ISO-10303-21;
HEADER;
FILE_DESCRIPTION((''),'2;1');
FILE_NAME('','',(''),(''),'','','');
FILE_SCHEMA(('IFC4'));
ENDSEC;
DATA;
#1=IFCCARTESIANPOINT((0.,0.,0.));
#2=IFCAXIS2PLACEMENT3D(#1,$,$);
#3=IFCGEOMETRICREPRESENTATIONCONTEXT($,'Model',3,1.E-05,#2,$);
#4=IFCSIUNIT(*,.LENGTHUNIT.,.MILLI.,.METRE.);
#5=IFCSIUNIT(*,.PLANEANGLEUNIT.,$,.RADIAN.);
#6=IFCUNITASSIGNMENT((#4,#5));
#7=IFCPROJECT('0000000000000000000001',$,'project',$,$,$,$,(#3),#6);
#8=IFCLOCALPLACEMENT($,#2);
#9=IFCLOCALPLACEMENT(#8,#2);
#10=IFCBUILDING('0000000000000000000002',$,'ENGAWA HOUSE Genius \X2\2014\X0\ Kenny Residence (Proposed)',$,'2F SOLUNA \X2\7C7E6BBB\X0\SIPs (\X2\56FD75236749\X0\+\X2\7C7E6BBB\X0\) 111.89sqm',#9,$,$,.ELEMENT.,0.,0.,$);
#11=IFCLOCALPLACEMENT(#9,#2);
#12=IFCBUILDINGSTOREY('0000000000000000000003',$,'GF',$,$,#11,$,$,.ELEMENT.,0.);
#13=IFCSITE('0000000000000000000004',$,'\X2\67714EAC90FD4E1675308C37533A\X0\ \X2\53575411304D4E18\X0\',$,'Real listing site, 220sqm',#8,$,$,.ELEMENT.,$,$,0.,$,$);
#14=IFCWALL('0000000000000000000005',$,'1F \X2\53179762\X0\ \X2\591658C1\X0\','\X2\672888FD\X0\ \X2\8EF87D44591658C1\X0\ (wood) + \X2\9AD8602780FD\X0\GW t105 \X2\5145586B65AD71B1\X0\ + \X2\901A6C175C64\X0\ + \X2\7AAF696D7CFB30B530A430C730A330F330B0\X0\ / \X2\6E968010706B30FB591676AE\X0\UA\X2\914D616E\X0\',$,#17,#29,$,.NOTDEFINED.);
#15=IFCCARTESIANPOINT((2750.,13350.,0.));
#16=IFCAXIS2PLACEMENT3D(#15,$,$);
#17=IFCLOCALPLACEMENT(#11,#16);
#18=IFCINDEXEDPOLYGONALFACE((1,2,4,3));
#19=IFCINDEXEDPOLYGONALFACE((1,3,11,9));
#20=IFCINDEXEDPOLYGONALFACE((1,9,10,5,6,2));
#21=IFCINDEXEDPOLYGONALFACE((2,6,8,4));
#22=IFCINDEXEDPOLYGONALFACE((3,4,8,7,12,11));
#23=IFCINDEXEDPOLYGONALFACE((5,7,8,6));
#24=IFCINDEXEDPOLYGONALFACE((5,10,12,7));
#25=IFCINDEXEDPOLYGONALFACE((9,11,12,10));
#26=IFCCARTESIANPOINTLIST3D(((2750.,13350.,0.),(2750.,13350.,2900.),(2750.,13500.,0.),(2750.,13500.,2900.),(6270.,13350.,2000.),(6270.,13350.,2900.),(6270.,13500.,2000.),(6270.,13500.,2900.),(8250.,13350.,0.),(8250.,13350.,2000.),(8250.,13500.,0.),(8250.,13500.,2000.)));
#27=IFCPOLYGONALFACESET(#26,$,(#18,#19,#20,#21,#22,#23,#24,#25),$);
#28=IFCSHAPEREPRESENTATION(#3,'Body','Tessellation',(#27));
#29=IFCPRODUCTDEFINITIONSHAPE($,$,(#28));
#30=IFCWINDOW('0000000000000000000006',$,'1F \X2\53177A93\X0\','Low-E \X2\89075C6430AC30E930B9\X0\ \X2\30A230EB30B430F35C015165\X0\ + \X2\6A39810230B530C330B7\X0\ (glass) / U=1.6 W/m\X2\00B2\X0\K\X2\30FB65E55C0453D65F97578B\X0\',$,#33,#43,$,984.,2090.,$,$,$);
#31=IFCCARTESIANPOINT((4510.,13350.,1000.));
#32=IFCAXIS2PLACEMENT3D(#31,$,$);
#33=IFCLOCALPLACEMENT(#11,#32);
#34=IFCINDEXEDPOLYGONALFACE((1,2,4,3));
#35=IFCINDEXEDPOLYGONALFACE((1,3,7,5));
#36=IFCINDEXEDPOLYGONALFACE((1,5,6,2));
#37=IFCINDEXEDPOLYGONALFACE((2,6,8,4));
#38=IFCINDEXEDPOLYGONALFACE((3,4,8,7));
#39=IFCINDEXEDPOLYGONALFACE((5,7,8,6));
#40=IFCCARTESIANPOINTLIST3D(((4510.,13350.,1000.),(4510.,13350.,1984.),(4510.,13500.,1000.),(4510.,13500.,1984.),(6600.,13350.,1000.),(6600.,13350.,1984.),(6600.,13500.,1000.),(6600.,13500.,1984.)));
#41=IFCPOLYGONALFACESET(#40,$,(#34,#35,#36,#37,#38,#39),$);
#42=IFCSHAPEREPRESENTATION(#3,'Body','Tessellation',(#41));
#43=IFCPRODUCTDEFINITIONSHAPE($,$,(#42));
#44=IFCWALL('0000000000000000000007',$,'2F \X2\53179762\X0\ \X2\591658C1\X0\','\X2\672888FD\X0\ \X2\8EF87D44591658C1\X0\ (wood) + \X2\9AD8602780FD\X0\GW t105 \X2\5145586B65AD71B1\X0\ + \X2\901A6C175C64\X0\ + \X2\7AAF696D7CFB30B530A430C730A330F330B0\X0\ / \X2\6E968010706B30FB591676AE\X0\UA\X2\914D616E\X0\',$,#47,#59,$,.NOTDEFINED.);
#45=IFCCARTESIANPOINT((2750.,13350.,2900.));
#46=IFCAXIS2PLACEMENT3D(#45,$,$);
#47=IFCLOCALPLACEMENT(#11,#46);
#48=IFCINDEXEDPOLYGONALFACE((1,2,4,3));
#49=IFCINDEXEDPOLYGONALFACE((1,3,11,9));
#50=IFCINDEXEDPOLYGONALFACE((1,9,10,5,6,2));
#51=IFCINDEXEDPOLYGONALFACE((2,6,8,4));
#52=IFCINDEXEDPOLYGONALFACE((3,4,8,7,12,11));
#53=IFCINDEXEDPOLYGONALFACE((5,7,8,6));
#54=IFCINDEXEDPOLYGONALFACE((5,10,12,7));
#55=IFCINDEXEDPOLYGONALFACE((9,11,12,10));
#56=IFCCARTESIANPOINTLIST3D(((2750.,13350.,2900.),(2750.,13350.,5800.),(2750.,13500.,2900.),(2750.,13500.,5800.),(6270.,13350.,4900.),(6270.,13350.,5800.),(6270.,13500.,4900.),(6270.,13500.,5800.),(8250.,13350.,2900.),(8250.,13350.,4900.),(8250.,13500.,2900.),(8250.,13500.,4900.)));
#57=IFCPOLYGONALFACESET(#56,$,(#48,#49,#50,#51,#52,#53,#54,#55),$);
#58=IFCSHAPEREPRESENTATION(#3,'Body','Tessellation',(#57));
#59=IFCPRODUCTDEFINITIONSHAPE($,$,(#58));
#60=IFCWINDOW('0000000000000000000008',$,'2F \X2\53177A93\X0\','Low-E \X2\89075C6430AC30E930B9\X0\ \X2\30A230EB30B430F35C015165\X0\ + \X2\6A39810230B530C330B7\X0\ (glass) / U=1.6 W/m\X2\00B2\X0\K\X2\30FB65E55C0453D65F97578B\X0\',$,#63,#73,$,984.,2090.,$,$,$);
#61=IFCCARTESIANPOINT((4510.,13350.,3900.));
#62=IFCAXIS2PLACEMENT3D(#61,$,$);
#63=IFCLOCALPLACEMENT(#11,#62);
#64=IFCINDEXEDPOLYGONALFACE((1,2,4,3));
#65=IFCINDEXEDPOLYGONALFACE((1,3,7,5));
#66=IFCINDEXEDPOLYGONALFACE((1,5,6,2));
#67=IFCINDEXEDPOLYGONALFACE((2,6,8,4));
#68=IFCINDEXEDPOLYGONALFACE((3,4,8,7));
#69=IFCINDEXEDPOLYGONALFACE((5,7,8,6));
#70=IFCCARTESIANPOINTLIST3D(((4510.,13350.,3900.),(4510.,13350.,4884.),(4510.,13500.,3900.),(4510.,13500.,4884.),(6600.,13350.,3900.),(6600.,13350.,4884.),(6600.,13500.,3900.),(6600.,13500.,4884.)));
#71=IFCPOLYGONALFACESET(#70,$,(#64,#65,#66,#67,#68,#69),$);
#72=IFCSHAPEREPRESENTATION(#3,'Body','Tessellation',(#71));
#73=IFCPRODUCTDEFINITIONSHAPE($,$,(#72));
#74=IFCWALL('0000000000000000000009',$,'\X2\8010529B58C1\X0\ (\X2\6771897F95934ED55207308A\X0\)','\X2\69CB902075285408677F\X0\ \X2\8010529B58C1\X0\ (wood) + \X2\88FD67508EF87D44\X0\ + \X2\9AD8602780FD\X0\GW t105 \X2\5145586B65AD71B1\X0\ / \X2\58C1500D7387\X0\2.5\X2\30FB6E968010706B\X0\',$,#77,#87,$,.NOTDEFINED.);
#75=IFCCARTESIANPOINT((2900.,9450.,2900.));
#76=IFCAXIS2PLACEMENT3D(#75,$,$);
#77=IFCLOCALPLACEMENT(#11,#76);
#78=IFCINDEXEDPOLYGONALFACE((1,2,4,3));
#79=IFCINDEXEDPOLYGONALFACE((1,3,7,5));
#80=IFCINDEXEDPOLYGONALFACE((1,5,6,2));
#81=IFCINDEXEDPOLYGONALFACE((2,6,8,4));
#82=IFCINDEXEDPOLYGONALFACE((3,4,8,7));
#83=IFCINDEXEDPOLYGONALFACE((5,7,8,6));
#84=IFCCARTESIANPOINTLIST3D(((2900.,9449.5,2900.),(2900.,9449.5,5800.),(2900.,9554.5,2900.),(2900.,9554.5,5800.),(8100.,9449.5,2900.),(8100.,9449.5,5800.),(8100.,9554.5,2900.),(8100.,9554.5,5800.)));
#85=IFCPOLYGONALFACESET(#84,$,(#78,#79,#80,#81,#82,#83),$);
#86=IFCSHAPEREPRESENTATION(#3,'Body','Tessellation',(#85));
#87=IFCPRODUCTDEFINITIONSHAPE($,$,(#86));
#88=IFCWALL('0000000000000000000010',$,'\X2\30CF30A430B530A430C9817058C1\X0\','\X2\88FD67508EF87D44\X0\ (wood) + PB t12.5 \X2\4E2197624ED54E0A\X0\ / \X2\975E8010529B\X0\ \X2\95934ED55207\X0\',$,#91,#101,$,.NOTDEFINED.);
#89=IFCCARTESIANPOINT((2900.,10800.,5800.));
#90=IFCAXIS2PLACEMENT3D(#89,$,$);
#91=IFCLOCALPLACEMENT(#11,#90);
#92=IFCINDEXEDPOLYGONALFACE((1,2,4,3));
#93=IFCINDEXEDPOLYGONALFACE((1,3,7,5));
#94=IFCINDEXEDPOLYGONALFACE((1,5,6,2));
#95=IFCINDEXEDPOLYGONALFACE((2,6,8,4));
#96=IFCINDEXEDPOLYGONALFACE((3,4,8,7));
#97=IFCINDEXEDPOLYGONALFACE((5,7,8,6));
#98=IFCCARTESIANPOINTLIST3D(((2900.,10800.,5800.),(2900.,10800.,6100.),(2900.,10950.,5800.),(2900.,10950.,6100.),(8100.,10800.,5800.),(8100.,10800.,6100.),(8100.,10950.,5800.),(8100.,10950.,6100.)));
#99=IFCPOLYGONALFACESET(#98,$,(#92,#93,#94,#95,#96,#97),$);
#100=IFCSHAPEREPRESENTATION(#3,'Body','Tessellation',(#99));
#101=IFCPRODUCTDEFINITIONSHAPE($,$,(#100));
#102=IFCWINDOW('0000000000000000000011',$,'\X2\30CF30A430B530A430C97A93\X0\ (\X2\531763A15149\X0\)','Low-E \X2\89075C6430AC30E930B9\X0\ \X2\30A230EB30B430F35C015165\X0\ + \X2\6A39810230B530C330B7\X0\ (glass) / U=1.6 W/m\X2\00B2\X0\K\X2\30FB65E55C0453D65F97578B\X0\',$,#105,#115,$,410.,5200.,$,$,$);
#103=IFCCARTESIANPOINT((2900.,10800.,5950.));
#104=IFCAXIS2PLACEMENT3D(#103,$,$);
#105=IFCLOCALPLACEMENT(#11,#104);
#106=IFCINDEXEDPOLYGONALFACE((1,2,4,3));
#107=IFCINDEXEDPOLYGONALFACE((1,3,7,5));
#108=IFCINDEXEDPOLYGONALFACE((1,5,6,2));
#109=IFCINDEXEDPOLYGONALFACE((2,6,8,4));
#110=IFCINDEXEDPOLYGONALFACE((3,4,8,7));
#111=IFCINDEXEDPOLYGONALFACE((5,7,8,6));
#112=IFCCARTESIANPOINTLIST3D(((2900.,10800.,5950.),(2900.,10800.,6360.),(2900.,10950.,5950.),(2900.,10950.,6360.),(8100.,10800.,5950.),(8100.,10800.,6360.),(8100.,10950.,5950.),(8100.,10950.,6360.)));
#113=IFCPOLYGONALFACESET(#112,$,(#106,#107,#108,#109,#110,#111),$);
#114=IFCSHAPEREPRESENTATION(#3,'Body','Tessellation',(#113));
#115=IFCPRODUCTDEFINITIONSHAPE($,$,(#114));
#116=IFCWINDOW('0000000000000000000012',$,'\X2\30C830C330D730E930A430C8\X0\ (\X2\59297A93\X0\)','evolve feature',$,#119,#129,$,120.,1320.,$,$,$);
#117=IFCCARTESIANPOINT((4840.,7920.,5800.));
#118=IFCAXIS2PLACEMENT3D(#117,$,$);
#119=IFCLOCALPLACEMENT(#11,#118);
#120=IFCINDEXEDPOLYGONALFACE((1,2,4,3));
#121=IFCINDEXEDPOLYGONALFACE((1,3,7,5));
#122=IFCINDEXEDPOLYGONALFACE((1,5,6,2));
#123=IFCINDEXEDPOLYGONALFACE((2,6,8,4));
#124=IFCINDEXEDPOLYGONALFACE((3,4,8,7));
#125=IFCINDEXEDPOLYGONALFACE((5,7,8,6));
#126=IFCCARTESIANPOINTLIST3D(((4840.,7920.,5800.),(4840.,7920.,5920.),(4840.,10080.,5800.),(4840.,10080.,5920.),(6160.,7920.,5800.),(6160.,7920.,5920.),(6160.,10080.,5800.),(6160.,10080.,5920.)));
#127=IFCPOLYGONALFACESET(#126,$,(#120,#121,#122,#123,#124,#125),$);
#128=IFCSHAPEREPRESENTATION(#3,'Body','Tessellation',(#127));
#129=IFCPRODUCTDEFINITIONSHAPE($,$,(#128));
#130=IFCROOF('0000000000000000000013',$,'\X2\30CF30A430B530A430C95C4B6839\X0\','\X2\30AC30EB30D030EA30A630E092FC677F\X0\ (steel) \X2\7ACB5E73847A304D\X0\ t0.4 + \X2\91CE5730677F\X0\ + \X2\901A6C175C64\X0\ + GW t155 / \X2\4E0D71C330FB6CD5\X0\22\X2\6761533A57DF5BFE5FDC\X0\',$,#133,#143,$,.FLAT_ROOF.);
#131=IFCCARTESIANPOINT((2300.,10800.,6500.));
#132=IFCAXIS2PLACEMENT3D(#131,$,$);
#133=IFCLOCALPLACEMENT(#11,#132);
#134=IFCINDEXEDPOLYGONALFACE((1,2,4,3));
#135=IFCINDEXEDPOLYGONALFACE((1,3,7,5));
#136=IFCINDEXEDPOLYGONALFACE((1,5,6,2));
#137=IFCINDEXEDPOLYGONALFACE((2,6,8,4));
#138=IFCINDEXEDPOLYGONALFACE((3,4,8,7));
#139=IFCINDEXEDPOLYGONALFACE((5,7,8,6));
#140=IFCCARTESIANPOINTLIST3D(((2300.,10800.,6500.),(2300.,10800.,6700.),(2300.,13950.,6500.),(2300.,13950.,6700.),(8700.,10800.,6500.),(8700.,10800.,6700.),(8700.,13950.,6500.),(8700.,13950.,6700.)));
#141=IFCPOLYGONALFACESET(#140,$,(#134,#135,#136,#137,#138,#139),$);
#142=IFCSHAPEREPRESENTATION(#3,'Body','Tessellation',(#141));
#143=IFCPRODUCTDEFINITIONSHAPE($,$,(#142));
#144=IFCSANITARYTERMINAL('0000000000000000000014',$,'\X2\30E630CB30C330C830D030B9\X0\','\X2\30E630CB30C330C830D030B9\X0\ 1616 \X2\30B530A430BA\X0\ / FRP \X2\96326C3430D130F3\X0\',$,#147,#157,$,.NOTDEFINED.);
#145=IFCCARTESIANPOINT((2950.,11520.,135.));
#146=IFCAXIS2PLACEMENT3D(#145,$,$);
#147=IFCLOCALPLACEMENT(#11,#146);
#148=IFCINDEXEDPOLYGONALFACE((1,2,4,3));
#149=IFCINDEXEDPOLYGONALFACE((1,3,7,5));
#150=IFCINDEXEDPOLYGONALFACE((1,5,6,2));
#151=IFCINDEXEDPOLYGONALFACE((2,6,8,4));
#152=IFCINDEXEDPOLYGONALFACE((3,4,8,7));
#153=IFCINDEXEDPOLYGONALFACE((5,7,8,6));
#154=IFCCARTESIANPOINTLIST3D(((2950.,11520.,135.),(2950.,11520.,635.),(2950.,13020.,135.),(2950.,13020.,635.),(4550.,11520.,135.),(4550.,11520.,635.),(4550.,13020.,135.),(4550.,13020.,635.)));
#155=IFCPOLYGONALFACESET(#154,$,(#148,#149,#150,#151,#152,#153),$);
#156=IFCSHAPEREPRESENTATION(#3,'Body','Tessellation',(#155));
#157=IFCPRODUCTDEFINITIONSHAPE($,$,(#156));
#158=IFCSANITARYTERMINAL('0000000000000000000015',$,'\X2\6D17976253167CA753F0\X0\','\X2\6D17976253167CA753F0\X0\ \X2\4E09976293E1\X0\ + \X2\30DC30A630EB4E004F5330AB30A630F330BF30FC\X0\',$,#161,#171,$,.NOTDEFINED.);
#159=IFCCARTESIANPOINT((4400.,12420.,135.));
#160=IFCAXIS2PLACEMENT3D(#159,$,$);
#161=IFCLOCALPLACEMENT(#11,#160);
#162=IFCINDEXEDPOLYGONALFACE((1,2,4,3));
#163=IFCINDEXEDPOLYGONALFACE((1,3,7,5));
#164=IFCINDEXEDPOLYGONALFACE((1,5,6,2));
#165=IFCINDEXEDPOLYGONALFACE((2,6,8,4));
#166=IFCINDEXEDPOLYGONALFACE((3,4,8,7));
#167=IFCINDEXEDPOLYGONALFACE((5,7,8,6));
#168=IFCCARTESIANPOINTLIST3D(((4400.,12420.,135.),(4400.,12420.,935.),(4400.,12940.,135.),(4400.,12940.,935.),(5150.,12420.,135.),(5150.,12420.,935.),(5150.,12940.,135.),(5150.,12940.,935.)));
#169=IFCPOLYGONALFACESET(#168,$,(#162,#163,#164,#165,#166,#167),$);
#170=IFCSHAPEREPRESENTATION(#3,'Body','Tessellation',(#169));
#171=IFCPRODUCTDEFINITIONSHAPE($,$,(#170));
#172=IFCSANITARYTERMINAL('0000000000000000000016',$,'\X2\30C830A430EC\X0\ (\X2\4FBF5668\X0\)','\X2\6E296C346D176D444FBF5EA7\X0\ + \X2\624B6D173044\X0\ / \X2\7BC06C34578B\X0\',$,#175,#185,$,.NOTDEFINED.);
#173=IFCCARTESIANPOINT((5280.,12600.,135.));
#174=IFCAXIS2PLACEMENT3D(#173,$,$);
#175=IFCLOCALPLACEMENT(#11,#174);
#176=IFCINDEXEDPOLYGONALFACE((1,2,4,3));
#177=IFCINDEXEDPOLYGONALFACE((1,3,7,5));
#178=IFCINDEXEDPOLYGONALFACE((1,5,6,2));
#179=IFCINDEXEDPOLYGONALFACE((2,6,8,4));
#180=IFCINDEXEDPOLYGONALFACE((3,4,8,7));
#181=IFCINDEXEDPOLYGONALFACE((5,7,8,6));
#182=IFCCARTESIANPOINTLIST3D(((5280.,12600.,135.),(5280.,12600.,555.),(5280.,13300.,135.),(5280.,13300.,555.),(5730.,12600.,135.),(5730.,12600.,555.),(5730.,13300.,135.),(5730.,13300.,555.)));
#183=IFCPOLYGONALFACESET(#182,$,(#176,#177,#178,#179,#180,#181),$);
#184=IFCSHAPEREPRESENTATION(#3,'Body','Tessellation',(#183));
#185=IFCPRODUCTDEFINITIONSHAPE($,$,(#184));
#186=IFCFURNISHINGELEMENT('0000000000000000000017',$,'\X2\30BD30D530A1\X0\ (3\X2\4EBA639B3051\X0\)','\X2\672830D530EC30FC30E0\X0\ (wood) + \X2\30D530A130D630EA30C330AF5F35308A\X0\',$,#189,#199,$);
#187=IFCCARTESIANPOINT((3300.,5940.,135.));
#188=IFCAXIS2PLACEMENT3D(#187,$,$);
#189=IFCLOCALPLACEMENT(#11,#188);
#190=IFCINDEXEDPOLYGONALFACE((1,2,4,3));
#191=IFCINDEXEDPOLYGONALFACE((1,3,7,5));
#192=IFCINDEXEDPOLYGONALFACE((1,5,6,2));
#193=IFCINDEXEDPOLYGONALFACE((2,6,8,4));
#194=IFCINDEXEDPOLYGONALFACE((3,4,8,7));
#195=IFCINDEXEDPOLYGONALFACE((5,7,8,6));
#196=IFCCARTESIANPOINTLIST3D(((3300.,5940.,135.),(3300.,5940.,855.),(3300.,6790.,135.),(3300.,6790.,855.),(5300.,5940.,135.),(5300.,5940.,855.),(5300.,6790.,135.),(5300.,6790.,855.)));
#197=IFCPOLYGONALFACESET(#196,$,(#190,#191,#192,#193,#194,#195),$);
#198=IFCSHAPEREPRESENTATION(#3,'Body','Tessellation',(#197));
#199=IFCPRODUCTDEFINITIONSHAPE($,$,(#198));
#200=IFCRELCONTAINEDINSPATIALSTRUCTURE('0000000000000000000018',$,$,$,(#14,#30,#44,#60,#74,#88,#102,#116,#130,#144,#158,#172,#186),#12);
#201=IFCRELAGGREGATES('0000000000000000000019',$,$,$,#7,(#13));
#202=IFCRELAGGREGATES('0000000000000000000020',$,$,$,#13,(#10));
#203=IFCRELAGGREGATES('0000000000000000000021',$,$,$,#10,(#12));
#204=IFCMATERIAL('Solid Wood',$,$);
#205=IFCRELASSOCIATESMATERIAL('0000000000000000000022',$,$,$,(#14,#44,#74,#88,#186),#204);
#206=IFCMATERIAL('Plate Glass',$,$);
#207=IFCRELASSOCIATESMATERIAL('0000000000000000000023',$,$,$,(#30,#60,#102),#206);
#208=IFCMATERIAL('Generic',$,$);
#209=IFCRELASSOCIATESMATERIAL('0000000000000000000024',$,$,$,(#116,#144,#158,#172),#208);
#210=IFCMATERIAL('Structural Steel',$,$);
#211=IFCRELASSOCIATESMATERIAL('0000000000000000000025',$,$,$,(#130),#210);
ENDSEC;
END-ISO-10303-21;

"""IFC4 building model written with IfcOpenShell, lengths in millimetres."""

from ifc_helpers import new_model, si_unit, frame, frame_2d, origin, place, context, project, spatial, rectangle, extrude, material, element, fill, save


model = new_model("IFC4")

# Units and contexts
model_context = context("Model", 3, precision=1e-05, world=origin())
ifc_project = project(units=[si_unit("LENGTHUNIT", "METRE", prefix="MILLI"), si_unit("PLANEANGLEUNIT", "RADIAN")], contexts=[model_context])

# Site, building, storey
site_placement = place(None, origin())
site = spatial("IfcSite", under=ifc_project, at=site_placement, Name="東京都世田谷区 南向き丘", ObjectType="Real listing site, 220sqm", CompositionType="ELEMENT", RefElevation=0.0)
building_placement = place(site_placement, origin())
building = spatial("IfcBuilding", under=site, at=building_placement, Name="ENGAWA HOUSE Genius — Kenny Residence (Proposed)", ObjectType="2F SOLUNA 籾殻SIPs (国産杉+籾殻) 111.89sqm", CompositionType="ELEMENT", ElevationOfRefHeight=0.0, ElevationOfTerrain=0.0)
storey_placement = place(building_placement, origin())
storey = spatial("IfcBuildingStorey", under=building, at=storey_placement, Name="GF", CompositionType="ELEMENT", Elevation=0.0)

# Wall, opening, window
ifc_material_1 = material(Name="Solid Wood")
wall_1_placement = place(storey_placement, frame((2750.0, 13350.0, 0.0)))
wall_1 = element("IfcWall", 1, at=wall_1_placement, inside=storey, material=ifc_material_1, Name="1F 北面 外壁", Description="木製 軸組外壁 (wood) + 高性能GW t105 充填断熱 + 通気層 + 窯業系サイディング / 準耐火・外皮UA配慮", PredefinedType="NOTDEFINED", context=model_context, shape_type="SweptSolid", body=[
    extrude(rectangle(XDim=5500.0, YDim=150.0, at=frame_2d((2750.0, 75.0))), frame((2750.0, 13350.0, 0.0)), (0.0, 0.0, 1.0), 2900.0),
])
opening_1_placement = place(storey_placement, frame((4510.0, 13350.0, 1000.0)))
opening_1 = element("IfcOpeningElement", 2, at=opening_1_placement, cuts=wall_1, PredefinedType="NOTDEFINED", context=model_context, shape_type="SweptSolid", body=[
    extrude(rectangle(XDim=2090.0, YDim=150.0, at=frame_2d((1045.0, 75.0))), frame((4510.0, 13350.0, 1000.0)), (0.0, 0.0, 1.0), 984.0),
])
ifc_material_2 = material(Name="Plate Glass")
window_1_placement = place(storey_placement, frame((4510.0, 13350.0, 1000.0)))
window_1 = element("IfcWindow", 3, at=window_1_placement, inside=storey, material=ifc_material_2, Name="1F 北窓", Description="Low-E 複層ガラス アルゴン封入 + 樹脂サッシ (glass) / U=1.6 W/m²K・日射取得型", OverallHeight=984.0, OverallWidth=2090.0, context=model_context, shape_type="SweptSolid", body=[
    extrude(rectangle(XDim=2090.0, YDim=150.0, at=frame_2d((1045.0, 75.0))), frame((4510.0, 13350.0, 1000.0)), (0.0, 0.0, 1.0), 984.0),
])
fill(opening_1, window_1)

# Wall, opening, window
wall_2_placement = place(storey_placement, frame((2750.0, 13350.0, 2900.0)))
wall_2 = element("IfcWall", 4, at=wall_2_placement, inside=storey, material=ifc_material_1, Name="2F 北面 外壁", Description="木製 軸組外壁 (wood) + 高性能GW t105 充填断熱 + 通気層 + 窯業系サイディング / 準耐火・外皮UA配慮", PredefinedType="NOTDEFINED", context=model_context, shape_type="SweptSolid", body=[
    extrude(rectangle(XDim=5500.0, YDim=150.0, at=frame_2d((2750.0, 75.0))), frame((2750.0, 13350.0, 2900.0)), (0.0, 0.0, 1.0), 2900.0),
])
opening_2_placement = place(storey_placement, frame((4510.0, 13350.0, 3900.0)))
opening_2 = element("IfcOpeningElement", 5, at=opening_2_placement, cuts=wall_2, PredefinedType="NOTDEFINED", context=model_context, shape_type="SweptSolid", body=[
    extrude(rectangle(XDim=2090.0, YDim=150.0, at=frame_2d((1045.0, 75.0))), frame((4510.0, 13350.0, 3900.0)), (0.0, 0.0, 1.0), 984.0),
])
window_2_placement = place(storey_placement, frame((4510.0, 13350.0, 3900.0)))
window_2 = element("IfcWindow", 6, at=window_2_placement, inside=storey, material=ifc_material_2, Name="2F 北窓", Description="Low-E 複層ガラス アルゴン封入 + 樹脂サッシ (glass) / U=1.6 W/m²K・日射取得型", OverallHeight=984.0, OverallWidth=2090.0, context=model_context, shape_type="SweptSolid", body=[
    extrude(rectangle(XDim=2090.0, YDim=150.0, at=frame_2d((1045.0, 75.0))), frame((4510.0, 13350.0, 3900.0)), (0.0, 0.0, 1.0), 984.0),
])
fill(opening_2, window_2)

# Wall
wall_3_placement = place(storey_placement, frame((2900.0, 9450.0, 2900.0)))
element("IfcWall", 7, at=wall_3_placement, inside=storey, material=ifc_material_1, Name="耐力壁 (東西間仕切り)", Description="構造用合板 耐力壁 (wood) + 製材軸組 + 高性能GW t105 充填断熱 / 壁倍率2.5・準耐火", PredefinedType="NOTDEFINED", context=model_context, shape_type="SweptSolid", body=[
    extrude(rectangle(XDim=5200.0, YDim=105.0, at=frame_2d((2600.0, 52.0))), frame((2900.0, 9450.0, 2900.0)), (0.0, 0.0, 1.0), 2900.0),
])

# Wall, opening, window
wall_4_placement = place(storey_placement, frame((2900.0, 10800.0, 5800.0)))
wall_4 = element("IfcWall", 8, at=wall_4_placement, inside=storey, material=ifc_material_1, Name="ハイサイド腰壁", Description="製材軸組 (wood) + PB t12.5 両面仕上 / 非耐力 間仕切", PredefinedType="NOTDEFINED", context=model_context, shape_type="SweptSolid", body=[
    extrude(rectangle(XDim=5200.0, YDim=150.0, at=frame_2d((2600.0, 75.0))), frame((2900.0, 10800.0, 5800.0)), (0.0, 0.0, 1.0), 700.0),
])
opening_3_placement = place(storey_placement, frame((2900.0, 10800.0, 5950.0)))
opening_3 = element("IfcOpeningElement", 9, at=opening_3_placement, cuts=wall_4, PredefinedType="NOTDEFINED", context=model_context, shape_type="SweptSolid", body=[
    extrude(rectangle(XDim=5200.0, YDim=150.0, at=frame_2d((2600.0, 75.0))), frame((2900.0, 10800.0, 5950.0)), (0.0, 0.0, 1.0), 410.0),
])
window_3_placement = place(storey_placement, frame((2900.0, 10800.0, 5950.0)))
window_3 = element("IfcWindow", 10, at=window_3_placement, inside=storey, material=ifc_material_2, Name="ハイサイド窓 (北採光)", Description="Low-E 複層ガラス アルゴン封入 + 樹脂サッシ (glass) / U=1.6 W/m²K・日射取得型", OverallHeight=410.0, OverallWidth=5200.0, context=model_context, shape_type="SweptSolid", body=[
    extrude(rectangle(XDim=5200.0, YDim=150.0, at=frame_2d((2600.0, 75.0))), frame((2900.0, 10800.0, 5950.0)), (0.0, 0.0, 1.0), 410.0),
])
fill(opening_3, window_3)

# Window
ifc_material_3 = material(Name="Generic")
window_4_placement = place(storey_placement, frame((4840.0, 7920.0, 5800.0)))
element("IfcWindow", 11, at=window_4_placement, inside=storey, material=ifc_material_3, Name="トップライト (天窓)", Description="evolve feature", OverallHeight=120.0, OverallWidth=1320.0, context=model_context, shape_type="SweptSolid", body=[
    extrude(rectangle(XDim=1320.0, YDim=2160.0, at=frame_2d((660.0, 1080.0))), frame((4840.0, 7920.0, 5800.0)), (0.0, 0.0, 1.0), 120.0),
])

# Roof
ifc_material_4 = material(Name="Structural Steel")
roof_placement = place(storey_placement, frame((2300.0, 10800.0, 6500.0)))
element("IfcRoof", 12, at=roof_placement, inside=storey, material=ifc_material_4, Name="ハイサイド屋根", Description="ガルバリウム鋼板 (steel) 立平葺き t0.4 + 野地板 + 通気層 + GW t155 / 不燃・法22条区域対応", PredefinedType="FLAT_ROOF", context=model_context, shape_type="SweptSolid", body=[
    extrude(rectangle(XDim=6400.0, YDim=3150.0, at=frame_2d((3200.0, 1575.0))), frame((2300.0, 10800.0, 6500.0)), (0.0, 0.0, 1.0), 200.0),
])

# Sanitary terminals
sanitary_terminal_1_placement = place(storey_placement, frame((2950.0, 11520.0, 135.0)))
element("IfcSanitaryTerminal", 13, at=sanitary_terminal_1_placement, inside=storey, material=ifc_material_3, Name="ユニットバス", Description="ユニットバス 1616 サイズ / FRP 防水パン", PredefinedType="NOTDEFINED", context=model_context, shape_type="SweptSolid", body=[
    extrude(rectangle(XDim=1600.0, YDim=1500.0, at=frame_2d((800.0, 750.0))), frame((2950.0, 11520.0, 135.0)), (0.0, 0.0, 1.0), 500.0),
])
sanitary_terminal_2_placement = place(storey_placement, frame((4400.0, 12420.0, 135.0)))
element("IfcSanitaryTerminal", 14, at=sanitary_terminal_2_placement, inside=storey, material=ifc_material_3, Name="洗面化粧台", Description="洗面化粧台 三面鏡 + ボウル一体カウンター", PredefinedType="NOTDEFINED", context=model_context, shape_type="SweptSolid", body=[
    extrude(rectangle(XDim=750.0, YDim=520.0, at=frame_2d((375.0, 260.0))), frame((4400.0, 12420.0, 135.0)), (0.0, 0.0, 1.0), 800.0),
])
sanitary_terminal_3_placement = place(storey_placement, frame((5280.0, 12600.0, 135.0)))
element("IfcSanitaryTerminal", 15, at=sanitary_terminal_3_placement, inside=storey, material=ifc_material_3, Name="トイレ (便器)", Description="温水洗浄便座 + 手洗い / 節水型", PredefinedType="NOTDEFINED", context=model_context, shape_type="SweptSolid", body=[
    extrude(rectangle(XDim=450.0, YDim=700.0, at=frame_2d((225.0, 350.0))), frame((5280.0, 12600.0, 135.0)), (0.0, 0.0, 1.0), 420.0),
])

# Furnishing element
furnishing_1_placement = place(storey_placement, frame((3300.0, 5940.0, 135.0)))
element("IfcFurnishingElement", 16, at=furnishing_1_placement, inside=storey, material=ifc_material_1, Name="ソファ (3人掛け)", Description="木フレーム (wood) + ファブリック張り", context=model_context, shape_type="SweptSolid", body=[
    extrude(rectangle(XDim=2000.0, YDim=850.0, at=frame_2d((1000.0, 425.0))), frame((3300.0, 5940.0, 135.0)), (0.0, 0.0, 1.0), 720.0),
])

save(model, "model.ifc")
